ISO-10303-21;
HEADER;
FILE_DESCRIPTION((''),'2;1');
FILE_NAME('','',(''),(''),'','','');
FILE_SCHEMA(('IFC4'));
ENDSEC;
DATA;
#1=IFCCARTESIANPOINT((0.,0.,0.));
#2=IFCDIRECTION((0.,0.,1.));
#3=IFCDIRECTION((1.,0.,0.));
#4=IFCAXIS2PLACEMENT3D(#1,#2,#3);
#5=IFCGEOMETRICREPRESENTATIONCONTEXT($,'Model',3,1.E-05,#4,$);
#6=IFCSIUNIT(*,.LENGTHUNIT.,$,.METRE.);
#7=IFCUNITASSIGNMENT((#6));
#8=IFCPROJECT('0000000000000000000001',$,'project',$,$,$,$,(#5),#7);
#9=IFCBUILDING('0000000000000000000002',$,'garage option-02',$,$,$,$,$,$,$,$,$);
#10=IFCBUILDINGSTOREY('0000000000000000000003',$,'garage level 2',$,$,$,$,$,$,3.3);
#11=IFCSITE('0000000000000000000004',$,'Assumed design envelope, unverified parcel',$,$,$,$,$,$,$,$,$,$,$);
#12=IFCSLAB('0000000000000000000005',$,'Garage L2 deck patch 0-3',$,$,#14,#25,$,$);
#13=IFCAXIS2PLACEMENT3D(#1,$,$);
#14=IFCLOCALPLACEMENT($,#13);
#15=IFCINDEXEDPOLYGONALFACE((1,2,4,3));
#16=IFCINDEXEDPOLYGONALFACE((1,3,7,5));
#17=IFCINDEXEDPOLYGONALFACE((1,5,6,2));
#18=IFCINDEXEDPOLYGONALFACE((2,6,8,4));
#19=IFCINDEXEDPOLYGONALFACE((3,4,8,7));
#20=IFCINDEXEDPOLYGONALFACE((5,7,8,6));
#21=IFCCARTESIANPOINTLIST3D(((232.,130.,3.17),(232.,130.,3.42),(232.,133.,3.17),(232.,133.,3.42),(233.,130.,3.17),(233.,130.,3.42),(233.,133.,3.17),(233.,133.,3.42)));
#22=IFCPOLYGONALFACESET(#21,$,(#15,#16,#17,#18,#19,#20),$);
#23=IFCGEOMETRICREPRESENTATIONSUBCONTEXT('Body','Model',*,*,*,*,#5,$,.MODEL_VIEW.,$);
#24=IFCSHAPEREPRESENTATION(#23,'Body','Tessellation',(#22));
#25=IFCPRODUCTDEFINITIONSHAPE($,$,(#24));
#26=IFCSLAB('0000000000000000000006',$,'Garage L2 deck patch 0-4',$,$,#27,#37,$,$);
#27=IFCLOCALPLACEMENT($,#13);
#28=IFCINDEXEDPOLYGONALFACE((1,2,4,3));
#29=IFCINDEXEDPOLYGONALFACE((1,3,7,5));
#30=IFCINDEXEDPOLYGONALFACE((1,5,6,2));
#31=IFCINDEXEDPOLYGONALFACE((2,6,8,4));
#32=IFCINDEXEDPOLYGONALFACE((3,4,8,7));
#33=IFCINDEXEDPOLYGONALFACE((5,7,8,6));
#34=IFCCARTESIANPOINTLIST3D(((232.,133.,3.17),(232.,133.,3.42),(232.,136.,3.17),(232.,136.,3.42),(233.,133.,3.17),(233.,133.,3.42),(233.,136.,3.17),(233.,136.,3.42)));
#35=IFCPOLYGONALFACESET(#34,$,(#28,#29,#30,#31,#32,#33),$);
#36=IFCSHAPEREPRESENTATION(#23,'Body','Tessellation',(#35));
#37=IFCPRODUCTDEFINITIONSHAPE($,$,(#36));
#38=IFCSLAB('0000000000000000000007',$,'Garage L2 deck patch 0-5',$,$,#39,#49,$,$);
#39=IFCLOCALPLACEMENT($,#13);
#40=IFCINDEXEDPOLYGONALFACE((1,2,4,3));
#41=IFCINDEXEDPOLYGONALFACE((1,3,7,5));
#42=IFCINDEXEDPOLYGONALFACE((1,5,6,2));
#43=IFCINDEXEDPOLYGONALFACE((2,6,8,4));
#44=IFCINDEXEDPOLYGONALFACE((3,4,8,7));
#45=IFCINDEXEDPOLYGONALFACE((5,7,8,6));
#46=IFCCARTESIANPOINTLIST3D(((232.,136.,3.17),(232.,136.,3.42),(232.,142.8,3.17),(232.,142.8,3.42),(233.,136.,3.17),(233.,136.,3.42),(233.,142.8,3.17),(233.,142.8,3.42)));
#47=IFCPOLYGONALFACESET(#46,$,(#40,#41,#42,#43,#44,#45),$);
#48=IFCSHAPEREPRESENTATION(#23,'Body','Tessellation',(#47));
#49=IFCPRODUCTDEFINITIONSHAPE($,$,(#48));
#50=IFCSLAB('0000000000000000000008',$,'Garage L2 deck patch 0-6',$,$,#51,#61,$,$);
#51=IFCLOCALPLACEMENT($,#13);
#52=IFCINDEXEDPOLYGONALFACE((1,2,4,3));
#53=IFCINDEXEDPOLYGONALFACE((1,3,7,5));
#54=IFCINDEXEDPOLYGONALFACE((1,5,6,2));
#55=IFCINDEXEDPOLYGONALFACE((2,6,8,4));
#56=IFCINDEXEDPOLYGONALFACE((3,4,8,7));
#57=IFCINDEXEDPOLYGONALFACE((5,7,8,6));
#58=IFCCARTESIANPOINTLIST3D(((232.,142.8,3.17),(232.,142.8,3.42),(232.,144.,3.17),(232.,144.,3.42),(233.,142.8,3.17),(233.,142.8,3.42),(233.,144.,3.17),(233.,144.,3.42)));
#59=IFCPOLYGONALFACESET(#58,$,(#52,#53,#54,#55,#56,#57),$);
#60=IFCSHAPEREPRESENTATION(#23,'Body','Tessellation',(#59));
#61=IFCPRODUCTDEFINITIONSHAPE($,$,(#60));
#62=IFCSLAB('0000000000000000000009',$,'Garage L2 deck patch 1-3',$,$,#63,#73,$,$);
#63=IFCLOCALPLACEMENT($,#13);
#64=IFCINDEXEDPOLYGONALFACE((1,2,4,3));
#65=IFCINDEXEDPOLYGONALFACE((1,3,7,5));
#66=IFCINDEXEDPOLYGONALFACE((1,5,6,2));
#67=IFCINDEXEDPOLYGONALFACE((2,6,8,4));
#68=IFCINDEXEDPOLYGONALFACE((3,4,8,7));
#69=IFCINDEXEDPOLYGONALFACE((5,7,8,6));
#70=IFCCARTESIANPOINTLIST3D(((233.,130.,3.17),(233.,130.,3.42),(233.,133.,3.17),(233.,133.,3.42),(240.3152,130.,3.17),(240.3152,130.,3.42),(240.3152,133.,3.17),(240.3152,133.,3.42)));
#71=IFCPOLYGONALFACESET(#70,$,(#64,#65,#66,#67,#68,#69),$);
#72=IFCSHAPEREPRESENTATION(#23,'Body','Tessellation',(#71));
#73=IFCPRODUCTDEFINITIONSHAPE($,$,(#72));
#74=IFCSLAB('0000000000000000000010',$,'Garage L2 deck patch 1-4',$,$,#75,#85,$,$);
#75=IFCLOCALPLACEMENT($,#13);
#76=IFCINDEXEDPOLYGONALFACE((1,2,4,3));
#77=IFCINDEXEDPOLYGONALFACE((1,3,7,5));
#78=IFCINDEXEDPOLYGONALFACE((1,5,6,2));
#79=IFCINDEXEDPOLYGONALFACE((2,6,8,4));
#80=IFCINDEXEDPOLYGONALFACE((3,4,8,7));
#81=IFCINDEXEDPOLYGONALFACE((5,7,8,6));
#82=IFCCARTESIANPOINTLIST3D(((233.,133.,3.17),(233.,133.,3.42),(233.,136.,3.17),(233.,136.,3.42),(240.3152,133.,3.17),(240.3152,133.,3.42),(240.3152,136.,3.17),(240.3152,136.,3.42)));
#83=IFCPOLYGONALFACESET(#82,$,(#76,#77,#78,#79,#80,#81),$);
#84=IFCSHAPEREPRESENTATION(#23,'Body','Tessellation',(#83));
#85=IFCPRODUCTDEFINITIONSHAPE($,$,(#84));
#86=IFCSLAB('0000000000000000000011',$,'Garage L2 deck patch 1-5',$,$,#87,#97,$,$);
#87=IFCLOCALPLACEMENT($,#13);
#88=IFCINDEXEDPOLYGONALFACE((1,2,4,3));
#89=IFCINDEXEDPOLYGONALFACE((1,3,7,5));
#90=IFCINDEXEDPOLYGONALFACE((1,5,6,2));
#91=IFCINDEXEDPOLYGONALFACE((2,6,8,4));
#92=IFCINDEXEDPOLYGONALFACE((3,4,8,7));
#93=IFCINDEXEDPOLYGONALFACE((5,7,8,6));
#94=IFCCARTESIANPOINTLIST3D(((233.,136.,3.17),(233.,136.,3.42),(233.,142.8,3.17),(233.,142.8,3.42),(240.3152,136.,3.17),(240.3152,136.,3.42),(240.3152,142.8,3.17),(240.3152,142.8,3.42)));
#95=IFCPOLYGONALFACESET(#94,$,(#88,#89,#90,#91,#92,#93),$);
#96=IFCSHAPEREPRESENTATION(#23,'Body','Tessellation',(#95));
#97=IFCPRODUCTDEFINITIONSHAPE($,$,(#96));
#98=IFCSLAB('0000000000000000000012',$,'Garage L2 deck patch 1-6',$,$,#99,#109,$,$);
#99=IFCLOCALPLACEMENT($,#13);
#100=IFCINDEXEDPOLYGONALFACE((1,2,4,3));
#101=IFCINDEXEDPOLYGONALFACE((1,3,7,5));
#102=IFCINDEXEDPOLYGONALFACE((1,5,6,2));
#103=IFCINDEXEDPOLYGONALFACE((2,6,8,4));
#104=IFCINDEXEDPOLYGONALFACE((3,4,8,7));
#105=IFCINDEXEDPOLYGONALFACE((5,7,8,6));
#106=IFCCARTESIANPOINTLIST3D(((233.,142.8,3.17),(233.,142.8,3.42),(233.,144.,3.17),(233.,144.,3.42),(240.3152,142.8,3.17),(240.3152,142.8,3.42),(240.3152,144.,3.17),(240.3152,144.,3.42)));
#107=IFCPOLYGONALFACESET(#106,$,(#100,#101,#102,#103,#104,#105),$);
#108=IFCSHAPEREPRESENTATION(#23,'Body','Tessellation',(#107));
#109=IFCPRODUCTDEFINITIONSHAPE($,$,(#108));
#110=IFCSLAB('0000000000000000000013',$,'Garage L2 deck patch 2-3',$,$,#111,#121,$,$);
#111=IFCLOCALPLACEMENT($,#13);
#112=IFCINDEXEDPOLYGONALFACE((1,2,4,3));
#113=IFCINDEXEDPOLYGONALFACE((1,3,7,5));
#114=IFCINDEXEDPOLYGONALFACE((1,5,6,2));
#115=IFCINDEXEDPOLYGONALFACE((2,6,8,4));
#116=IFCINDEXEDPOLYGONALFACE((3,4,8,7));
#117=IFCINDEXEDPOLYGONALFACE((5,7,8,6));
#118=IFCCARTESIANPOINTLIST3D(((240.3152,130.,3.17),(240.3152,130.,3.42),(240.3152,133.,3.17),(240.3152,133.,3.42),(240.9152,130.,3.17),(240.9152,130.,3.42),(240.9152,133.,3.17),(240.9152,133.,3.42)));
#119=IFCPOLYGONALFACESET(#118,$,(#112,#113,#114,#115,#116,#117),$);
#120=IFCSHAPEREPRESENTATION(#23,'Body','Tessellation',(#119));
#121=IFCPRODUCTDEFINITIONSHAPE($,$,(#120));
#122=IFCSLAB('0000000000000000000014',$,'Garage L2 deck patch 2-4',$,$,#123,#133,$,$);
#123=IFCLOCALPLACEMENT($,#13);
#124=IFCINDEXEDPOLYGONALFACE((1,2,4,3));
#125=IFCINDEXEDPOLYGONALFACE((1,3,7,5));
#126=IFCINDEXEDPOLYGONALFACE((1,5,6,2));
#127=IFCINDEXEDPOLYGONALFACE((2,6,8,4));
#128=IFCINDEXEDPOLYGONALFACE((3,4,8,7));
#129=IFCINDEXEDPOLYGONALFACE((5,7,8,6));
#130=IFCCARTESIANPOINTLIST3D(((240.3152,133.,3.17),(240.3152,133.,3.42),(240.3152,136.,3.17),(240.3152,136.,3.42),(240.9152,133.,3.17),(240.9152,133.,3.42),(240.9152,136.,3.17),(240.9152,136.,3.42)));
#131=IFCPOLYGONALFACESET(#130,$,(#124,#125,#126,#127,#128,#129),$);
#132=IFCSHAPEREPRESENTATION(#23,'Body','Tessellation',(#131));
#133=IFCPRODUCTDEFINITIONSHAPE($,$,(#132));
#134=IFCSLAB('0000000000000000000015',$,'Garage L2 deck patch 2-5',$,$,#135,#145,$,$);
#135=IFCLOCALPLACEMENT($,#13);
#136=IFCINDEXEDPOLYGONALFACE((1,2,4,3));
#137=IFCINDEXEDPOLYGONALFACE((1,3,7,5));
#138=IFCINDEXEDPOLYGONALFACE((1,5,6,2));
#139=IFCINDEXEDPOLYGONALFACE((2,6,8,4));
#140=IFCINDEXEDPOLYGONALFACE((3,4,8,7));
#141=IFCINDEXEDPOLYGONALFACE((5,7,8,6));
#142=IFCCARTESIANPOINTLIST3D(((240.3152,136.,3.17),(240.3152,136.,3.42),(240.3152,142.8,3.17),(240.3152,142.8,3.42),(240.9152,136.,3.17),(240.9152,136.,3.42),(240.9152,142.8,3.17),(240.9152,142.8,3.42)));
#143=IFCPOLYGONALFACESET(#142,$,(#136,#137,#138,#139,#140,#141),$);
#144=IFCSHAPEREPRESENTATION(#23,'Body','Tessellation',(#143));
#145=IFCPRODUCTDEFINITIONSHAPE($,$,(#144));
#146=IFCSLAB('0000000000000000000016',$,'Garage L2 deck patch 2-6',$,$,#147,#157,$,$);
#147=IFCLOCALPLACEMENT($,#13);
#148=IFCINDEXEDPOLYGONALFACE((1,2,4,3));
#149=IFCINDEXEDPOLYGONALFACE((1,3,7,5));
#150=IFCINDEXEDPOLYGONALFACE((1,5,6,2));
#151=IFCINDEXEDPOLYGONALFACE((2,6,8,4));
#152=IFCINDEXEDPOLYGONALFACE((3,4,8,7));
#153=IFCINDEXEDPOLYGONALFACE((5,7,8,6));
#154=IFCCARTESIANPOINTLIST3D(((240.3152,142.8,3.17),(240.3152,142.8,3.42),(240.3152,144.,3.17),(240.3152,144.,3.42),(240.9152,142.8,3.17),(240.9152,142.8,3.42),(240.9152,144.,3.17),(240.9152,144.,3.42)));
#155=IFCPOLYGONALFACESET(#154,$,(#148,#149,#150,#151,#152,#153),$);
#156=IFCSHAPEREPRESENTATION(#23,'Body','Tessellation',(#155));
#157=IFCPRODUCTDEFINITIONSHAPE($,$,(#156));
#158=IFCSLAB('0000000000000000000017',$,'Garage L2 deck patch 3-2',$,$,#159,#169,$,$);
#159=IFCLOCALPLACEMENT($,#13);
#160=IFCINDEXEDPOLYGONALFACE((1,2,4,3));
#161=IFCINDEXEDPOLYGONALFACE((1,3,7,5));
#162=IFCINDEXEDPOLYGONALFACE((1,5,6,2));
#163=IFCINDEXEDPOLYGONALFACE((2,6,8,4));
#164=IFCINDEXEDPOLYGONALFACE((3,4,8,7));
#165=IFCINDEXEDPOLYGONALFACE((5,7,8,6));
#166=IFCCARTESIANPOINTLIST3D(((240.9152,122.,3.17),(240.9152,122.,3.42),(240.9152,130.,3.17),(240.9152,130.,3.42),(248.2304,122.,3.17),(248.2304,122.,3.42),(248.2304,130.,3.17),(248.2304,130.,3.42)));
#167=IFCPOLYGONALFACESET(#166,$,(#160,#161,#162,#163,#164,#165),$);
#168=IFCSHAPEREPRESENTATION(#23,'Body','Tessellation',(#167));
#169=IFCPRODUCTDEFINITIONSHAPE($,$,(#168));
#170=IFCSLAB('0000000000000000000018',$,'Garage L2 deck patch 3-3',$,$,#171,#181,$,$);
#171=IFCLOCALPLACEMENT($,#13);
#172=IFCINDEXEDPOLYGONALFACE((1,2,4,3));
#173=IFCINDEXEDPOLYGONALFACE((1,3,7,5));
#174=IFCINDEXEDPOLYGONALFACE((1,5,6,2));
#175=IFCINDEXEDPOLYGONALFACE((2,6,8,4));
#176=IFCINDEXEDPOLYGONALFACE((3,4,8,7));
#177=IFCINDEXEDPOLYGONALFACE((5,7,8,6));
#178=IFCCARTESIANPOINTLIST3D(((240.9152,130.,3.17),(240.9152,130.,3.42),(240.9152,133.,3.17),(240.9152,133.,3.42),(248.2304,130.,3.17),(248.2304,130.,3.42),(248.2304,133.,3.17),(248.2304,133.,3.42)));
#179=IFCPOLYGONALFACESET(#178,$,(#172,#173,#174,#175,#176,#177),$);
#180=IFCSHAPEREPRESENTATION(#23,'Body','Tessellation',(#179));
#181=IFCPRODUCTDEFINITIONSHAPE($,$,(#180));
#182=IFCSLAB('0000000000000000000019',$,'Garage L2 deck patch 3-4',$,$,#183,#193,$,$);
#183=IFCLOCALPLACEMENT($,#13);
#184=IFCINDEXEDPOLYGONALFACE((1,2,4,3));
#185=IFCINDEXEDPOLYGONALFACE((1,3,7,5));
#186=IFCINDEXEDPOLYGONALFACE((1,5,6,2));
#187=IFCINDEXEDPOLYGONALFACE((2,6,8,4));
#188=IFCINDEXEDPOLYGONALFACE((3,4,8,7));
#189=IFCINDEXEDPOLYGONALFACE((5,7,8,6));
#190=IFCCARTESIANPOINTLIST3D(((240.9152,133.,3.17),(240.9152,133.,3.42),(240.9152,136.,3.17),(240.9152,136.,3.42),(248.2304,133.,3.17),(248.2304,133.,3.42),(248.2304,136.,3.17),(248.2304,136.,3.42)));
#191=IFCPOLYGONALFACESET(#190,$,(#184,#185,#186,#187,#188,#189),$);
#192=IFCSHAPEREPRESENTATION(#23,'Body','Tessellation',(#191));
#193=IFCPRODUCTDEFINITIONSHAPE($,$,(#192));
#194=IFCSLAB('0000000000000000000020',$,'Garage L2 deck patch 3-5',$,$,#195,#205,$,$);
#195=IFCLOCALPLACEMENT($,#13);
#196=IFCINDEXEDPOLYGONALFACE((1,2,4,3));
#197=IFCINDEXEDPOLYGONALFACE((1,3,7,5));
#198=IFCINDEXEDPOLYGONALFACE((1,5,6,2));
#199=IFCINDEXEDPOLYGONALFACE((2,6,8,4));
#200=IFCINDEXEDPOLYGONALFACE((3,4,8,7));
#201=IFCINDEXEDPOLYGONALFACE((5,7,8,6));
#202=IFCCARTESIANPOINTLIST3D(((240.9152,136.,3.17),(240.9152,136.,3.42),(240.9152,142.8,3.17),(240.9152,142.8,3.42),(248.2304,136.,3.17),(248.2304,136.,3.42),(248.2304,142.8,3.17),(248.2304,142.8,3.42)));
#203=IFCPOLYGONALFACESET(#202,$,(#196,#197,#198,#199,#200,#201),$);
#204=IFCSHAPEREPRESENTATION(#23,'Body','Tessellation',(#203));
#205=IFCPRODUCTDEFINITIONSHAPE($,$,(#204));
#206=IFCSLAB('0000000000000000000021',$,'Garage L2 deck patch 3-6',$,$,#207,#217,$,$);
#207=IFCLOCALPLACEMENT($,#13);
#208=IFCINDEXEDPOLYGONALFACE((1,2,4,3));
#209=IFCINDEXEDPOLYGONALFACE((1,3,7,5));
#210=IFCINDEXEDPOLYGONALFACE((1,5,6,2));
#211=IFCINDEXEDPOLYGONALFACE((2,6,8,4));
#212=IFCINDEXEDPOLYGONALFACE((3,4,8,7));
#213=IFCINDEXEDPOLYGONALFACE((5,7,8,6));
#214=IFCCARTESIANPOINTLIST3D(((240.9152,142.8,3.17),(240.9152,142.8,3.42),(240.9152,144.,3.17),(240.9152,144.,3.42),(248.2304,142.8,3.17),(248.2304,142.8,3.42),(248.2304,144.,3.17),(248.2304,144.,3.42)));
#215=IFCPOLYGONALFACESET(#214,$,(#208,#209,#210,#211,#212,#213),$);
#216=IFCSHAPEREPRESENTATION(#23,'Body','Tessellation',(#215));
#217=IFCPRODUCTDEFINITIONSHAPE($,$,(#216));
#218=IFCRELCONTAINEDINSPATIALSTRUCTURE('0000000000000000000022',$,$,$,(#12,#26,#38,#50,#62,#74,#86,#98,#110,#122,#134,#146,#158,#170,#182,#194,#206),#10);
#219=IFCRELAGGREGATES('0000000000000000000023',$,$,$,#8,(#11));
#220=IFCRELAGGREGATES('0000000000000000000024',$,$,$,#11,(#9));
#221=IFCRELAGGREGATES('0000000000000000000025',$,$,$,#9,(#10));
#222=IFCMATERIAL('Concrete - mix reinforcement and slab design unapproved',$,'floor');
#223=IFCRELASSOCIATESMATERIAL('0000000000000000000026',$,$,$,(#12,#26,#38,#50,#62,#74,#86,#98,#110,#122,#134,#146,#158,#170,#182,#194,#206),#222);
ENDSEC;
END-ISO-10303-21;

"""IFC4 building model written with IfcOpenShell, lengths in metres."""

from ifc_helpers import new_model, si_unit, frame, origin_with_axes, place, context, subcontext, project, spatial, rectangle, extrude, material, element, save


model = new_model("IFC4")

# Units and contexts
model_context = context("Model", 3, precision=1e-05, world=origin_with_axes())
body_context = subcontext(model_context, "Body", "Model", "MODEL_VIEW")
ifc_project = project(units=[si_unit("LENGTHUNIT", "METRE")], contexts=[model_context])

# Site, building, storey
site = spatial("IfcSite", under=ifc_project, Name="Assumed design envelope, unverified parcel")
building = spatial("IfcBuilding", under=site, Name="garage option-02")
storey = spatial("IfcBuildingStorey", under=building, Name="garage level 2", Elevation=3.3)

# Slabs
ifc_material_1 = material(Name="Concrete - mix reinforcement and slab design unapproved", Category="floor")
for number, where, z_axis, x_axis, name in (
    (1, (232.5, 131.5, 3.17), (0.0, 0.0, 1.0), (1.0, 0.0, 0.0), "Garage L2 deck patch 0-3"),
    (2, (232.5, 134.5, 3.17), (0.0, 0.0, 1.0), (1.0, 0.0, 0.0), "Garage L2 deck patch 0-4"),
):
    element("IfcSlab", number, at=place(None, frame(where, z_axis=z_axis, x_axis=x_axis)), inside=storey, material=ifc_material_1, Name=name, context=body_context, shape_type="SweptSolid", body=[
        extrude(rectangle(XDim=1.0, YDim=3.0), origin_with_axes(), (0.0, 0.0, 1.0), 0.25),
    ])
slab_1_placement = place(None, frame((232.5, 139.4, 3.17), z_axis=(0.0, 0.0, 1.0), x_axis=(1.0, 0.0, 0.0)))
element("IfcSlab", 3, at=slab_1_placement, inside=storey, material=ifc_material_1, Name="Garage L2 deck patch 0-5", context=body_context, shape_type="SweptSolid", body=[
    extrude(rectangle(XDim=1.0, YDim=6.8), origin_with_axes(), (0.0, 0.0, 1.0), 0.25),
])
slab_2_placement = place(None, frame((232.5, 143.4, 3.17), z_axis=(0.0, 0.0, 1.0), x_axis=(1.0, 0.0, 0.0)))
element("IfcSlab", 4, at=slab_2_placement, inside=storey, material=ifc_material_1, Name="Garage L2 deck patch 0-6", context=body_context, shape_type="SweptSolid", body=[
    extrude(rectangle(XDim=1.0, YDim=1.2), origin_with_axes(), (0.0, 0.0, 1.0), 0.25),
])
for number, where, z_axis, x_axis, name in (
    (5, (236.6576, 131.5, 3.17), (0.0, 0.0, 1.0), (1.0, 0.0, 0.0), "Garage L2 deck patch 1-3"),
    (6, (236.6576, 134.5, 3.17), (0.0, 0.0, 1.0), (1.0, 0.0, 0.0), "Garage L2 deck patch 1-4"),
):
    element("IfcSlab", number, at=place(None, frame(where, z_axis=z_axis, x_axis=x_axis)), inside=storey, material=ifc_material_1, Name=name, context=body_context, shape_type="SweptSolid", body=[
        extrude(rectangle(XDim=7.3152, YDim=3.0), origin_with_axes(), (0.0, 0.0, 1.0), 0.25),
    ])
slab_3_placement = place(None, frame((236.6576, 139.4, 3.17), z_axis=(0.0, 0.0, 1.0), x_axis=(1.0, 0.0, 0.0)))
element("IfcSlab", 7, at=slab_3_placement, inside=storey, material=ifc_material_1, Name="Garage L2 deck patch 1-5", context=body_context, shape_type="SweptSolid", body=[
    extrude(rectangle(XDim=7.3152, YDim=6.8), origin_with_axes(), (0.0, 0.0, 1.0), 0.25),
])
slab_4_placement = place(None, frame((236.6576, 143.4, 3.17), z_axis=(0.0, 0.0, 1.0), x_axis=(1.0, 0.0, 0.0)))
element("IfcSlab", 8, at=slab_4_placement, inside=storey, material=ifc_material_1, Name="Garage L2 deck patch 1-6", context=body_context, shape_type="SweptSolid", body=[
    extrude(rectangle(XDim=7.3152, YDim=1.2), origin_with_axes(), (0.0, 0.0, 1.0), 0.25),
])
for number, where, z_axis, x_axis, name in (
    (9, (240.6152, 131.5, 3.17), (0.0, 0.0, 1.0), (1.0, 0.0, 0.0), "Garage L2 deck patch 2-3"),
    (10, (240.6152, 134.5, 3.17), (0.0, 0.0, 1.0), (1.0, 0.0, 0.0), "Garage L2 deck patch 2-4"),
):
    element("IfcSlab", number, at=place(None, frame(where, z_axis=z_axis, x_axis=x_axis)), inside=storey, material=ifc_material_1, Name=name, context=body_context, shape_type="SweptSolid", body=[
        extrude(rectangle(XDim=0.6, YDim=3.0), origin_with_axes(), (0.0, 0.0, 1.0), 0.25),
    ])
slab_5_placement = place(None, frame((240.6152, 139.4, 3.17), z_axis=(0.0, 0.0, 1.0), x_axis=(1.0, 0.0, 0.0)))
element("IfcSlab", 11, at=slab_5_placement, inside=storey, material=ifc_material_1, Name="Garage L2 deck patch 2-5", context=body_context, shape_type="SweptSolid", body=[
    extrude(rectangle(XDim=0.6, YDim=6.8), origin_with_axes(), (0.0, 0.0, 1.0), 0.25),
])
slab_6_placement = place(None, frame((240.6152, 143.4, 3.17), z_axis=(0.0, 0.0, 1.0), x_axis=(1.0, 0.0, 0.0)))
element("IfcSlab", 12, at=slab_6_placement, inside=storey, material=ifc_material_1, Name="Garage L2 deck patch 2-6", context=body_context, shape_type="SweptSolid", body=[
    extrude(rectangle(XDim=0.6, YDim=1.2), origin_with_axes(), (0.0, 0.0, 1.0), 0.25),
])
slab_7_placement = place(None, frame((244.5728, 126.0, 3.17), z_axis=(0.0, 0.0, 1.0), x_axis=(1.0, 0.0, 0.0)))
element("IfcSlab", 13, at=slab_7_placement, inside=storey, material=ifc_material_1, Name="Garage L2 deck patch 3-2", context=body_context, shape_type="SweptSolid", body=[
    extrude(rectangle(XDim=7.3152, YDim=8.0), origin_with_axes(), (0.0, 0.0, 1.0), 0.25),
])
for number, where, z_axis, x_axis, name in (
    (14, (244.5728, 131.5, 3.17), (0.0, 0.0, 1.0), (1.0, 0.0, 0.0), "Garage L2 deck patch 3-3"),
    (15, (244.5728, 134.5, 3.17), (0.0, 0.0, 1.0), (1.0, 0.0, 0.0), "Garage L2 deck patch 3-4"),
):
    element("IfcSlab", number, at=place(None, frame(where, z_axis=z_axis, x_axis=x_axis)), inside=storey, material=ifc_material_1, Name=name, context=body_context, shape_type="SweptSolid", body=[
        extrude(rectangle(XDim=7.3152, YDim=3.0), origin_with_axes(), (0.0, 0.0, 1.0), 0.25),
    ])
slab_8_placement = place(None, frame((244.5728, 139.4, 3.17), z_axis=(0.0, 0.0, 1.0), x_axis=(1.0, 0.0, 0.0)))
element("IfcSlab", 16, at=slab_8_placement, inside=storey, material=ifc_material_1, Name="Garage L2 deck patch 3-5", context=body_context, shape_type="SweptSolid", body=[
    extrude(rectangle(XDim=7.3152, YDim=6.8), origin_with_axes(), (0.0, 0.0, 1.0), 0.25),
])
slab_9_placement = place(None, frame((244.5728, 143.4, 3.17), z_axis=(0.0, 0.0, 1.0), x_axis=(1.0, 0.0, 0.0)))
element("IfcSlab", 17, at=slab_9_placement, inside=storey, material=ifc_material_1, Name="Garage L2 deck patch 3-6", context=body_context, shape_type="SweptSolid", body=[
    extrude(rectangle(XDim=7.3152, YDim=1.2), origin_with_axes(), (0.0, 0.0, 1.0), 0.25),
])

save(model, "model.ifc")
